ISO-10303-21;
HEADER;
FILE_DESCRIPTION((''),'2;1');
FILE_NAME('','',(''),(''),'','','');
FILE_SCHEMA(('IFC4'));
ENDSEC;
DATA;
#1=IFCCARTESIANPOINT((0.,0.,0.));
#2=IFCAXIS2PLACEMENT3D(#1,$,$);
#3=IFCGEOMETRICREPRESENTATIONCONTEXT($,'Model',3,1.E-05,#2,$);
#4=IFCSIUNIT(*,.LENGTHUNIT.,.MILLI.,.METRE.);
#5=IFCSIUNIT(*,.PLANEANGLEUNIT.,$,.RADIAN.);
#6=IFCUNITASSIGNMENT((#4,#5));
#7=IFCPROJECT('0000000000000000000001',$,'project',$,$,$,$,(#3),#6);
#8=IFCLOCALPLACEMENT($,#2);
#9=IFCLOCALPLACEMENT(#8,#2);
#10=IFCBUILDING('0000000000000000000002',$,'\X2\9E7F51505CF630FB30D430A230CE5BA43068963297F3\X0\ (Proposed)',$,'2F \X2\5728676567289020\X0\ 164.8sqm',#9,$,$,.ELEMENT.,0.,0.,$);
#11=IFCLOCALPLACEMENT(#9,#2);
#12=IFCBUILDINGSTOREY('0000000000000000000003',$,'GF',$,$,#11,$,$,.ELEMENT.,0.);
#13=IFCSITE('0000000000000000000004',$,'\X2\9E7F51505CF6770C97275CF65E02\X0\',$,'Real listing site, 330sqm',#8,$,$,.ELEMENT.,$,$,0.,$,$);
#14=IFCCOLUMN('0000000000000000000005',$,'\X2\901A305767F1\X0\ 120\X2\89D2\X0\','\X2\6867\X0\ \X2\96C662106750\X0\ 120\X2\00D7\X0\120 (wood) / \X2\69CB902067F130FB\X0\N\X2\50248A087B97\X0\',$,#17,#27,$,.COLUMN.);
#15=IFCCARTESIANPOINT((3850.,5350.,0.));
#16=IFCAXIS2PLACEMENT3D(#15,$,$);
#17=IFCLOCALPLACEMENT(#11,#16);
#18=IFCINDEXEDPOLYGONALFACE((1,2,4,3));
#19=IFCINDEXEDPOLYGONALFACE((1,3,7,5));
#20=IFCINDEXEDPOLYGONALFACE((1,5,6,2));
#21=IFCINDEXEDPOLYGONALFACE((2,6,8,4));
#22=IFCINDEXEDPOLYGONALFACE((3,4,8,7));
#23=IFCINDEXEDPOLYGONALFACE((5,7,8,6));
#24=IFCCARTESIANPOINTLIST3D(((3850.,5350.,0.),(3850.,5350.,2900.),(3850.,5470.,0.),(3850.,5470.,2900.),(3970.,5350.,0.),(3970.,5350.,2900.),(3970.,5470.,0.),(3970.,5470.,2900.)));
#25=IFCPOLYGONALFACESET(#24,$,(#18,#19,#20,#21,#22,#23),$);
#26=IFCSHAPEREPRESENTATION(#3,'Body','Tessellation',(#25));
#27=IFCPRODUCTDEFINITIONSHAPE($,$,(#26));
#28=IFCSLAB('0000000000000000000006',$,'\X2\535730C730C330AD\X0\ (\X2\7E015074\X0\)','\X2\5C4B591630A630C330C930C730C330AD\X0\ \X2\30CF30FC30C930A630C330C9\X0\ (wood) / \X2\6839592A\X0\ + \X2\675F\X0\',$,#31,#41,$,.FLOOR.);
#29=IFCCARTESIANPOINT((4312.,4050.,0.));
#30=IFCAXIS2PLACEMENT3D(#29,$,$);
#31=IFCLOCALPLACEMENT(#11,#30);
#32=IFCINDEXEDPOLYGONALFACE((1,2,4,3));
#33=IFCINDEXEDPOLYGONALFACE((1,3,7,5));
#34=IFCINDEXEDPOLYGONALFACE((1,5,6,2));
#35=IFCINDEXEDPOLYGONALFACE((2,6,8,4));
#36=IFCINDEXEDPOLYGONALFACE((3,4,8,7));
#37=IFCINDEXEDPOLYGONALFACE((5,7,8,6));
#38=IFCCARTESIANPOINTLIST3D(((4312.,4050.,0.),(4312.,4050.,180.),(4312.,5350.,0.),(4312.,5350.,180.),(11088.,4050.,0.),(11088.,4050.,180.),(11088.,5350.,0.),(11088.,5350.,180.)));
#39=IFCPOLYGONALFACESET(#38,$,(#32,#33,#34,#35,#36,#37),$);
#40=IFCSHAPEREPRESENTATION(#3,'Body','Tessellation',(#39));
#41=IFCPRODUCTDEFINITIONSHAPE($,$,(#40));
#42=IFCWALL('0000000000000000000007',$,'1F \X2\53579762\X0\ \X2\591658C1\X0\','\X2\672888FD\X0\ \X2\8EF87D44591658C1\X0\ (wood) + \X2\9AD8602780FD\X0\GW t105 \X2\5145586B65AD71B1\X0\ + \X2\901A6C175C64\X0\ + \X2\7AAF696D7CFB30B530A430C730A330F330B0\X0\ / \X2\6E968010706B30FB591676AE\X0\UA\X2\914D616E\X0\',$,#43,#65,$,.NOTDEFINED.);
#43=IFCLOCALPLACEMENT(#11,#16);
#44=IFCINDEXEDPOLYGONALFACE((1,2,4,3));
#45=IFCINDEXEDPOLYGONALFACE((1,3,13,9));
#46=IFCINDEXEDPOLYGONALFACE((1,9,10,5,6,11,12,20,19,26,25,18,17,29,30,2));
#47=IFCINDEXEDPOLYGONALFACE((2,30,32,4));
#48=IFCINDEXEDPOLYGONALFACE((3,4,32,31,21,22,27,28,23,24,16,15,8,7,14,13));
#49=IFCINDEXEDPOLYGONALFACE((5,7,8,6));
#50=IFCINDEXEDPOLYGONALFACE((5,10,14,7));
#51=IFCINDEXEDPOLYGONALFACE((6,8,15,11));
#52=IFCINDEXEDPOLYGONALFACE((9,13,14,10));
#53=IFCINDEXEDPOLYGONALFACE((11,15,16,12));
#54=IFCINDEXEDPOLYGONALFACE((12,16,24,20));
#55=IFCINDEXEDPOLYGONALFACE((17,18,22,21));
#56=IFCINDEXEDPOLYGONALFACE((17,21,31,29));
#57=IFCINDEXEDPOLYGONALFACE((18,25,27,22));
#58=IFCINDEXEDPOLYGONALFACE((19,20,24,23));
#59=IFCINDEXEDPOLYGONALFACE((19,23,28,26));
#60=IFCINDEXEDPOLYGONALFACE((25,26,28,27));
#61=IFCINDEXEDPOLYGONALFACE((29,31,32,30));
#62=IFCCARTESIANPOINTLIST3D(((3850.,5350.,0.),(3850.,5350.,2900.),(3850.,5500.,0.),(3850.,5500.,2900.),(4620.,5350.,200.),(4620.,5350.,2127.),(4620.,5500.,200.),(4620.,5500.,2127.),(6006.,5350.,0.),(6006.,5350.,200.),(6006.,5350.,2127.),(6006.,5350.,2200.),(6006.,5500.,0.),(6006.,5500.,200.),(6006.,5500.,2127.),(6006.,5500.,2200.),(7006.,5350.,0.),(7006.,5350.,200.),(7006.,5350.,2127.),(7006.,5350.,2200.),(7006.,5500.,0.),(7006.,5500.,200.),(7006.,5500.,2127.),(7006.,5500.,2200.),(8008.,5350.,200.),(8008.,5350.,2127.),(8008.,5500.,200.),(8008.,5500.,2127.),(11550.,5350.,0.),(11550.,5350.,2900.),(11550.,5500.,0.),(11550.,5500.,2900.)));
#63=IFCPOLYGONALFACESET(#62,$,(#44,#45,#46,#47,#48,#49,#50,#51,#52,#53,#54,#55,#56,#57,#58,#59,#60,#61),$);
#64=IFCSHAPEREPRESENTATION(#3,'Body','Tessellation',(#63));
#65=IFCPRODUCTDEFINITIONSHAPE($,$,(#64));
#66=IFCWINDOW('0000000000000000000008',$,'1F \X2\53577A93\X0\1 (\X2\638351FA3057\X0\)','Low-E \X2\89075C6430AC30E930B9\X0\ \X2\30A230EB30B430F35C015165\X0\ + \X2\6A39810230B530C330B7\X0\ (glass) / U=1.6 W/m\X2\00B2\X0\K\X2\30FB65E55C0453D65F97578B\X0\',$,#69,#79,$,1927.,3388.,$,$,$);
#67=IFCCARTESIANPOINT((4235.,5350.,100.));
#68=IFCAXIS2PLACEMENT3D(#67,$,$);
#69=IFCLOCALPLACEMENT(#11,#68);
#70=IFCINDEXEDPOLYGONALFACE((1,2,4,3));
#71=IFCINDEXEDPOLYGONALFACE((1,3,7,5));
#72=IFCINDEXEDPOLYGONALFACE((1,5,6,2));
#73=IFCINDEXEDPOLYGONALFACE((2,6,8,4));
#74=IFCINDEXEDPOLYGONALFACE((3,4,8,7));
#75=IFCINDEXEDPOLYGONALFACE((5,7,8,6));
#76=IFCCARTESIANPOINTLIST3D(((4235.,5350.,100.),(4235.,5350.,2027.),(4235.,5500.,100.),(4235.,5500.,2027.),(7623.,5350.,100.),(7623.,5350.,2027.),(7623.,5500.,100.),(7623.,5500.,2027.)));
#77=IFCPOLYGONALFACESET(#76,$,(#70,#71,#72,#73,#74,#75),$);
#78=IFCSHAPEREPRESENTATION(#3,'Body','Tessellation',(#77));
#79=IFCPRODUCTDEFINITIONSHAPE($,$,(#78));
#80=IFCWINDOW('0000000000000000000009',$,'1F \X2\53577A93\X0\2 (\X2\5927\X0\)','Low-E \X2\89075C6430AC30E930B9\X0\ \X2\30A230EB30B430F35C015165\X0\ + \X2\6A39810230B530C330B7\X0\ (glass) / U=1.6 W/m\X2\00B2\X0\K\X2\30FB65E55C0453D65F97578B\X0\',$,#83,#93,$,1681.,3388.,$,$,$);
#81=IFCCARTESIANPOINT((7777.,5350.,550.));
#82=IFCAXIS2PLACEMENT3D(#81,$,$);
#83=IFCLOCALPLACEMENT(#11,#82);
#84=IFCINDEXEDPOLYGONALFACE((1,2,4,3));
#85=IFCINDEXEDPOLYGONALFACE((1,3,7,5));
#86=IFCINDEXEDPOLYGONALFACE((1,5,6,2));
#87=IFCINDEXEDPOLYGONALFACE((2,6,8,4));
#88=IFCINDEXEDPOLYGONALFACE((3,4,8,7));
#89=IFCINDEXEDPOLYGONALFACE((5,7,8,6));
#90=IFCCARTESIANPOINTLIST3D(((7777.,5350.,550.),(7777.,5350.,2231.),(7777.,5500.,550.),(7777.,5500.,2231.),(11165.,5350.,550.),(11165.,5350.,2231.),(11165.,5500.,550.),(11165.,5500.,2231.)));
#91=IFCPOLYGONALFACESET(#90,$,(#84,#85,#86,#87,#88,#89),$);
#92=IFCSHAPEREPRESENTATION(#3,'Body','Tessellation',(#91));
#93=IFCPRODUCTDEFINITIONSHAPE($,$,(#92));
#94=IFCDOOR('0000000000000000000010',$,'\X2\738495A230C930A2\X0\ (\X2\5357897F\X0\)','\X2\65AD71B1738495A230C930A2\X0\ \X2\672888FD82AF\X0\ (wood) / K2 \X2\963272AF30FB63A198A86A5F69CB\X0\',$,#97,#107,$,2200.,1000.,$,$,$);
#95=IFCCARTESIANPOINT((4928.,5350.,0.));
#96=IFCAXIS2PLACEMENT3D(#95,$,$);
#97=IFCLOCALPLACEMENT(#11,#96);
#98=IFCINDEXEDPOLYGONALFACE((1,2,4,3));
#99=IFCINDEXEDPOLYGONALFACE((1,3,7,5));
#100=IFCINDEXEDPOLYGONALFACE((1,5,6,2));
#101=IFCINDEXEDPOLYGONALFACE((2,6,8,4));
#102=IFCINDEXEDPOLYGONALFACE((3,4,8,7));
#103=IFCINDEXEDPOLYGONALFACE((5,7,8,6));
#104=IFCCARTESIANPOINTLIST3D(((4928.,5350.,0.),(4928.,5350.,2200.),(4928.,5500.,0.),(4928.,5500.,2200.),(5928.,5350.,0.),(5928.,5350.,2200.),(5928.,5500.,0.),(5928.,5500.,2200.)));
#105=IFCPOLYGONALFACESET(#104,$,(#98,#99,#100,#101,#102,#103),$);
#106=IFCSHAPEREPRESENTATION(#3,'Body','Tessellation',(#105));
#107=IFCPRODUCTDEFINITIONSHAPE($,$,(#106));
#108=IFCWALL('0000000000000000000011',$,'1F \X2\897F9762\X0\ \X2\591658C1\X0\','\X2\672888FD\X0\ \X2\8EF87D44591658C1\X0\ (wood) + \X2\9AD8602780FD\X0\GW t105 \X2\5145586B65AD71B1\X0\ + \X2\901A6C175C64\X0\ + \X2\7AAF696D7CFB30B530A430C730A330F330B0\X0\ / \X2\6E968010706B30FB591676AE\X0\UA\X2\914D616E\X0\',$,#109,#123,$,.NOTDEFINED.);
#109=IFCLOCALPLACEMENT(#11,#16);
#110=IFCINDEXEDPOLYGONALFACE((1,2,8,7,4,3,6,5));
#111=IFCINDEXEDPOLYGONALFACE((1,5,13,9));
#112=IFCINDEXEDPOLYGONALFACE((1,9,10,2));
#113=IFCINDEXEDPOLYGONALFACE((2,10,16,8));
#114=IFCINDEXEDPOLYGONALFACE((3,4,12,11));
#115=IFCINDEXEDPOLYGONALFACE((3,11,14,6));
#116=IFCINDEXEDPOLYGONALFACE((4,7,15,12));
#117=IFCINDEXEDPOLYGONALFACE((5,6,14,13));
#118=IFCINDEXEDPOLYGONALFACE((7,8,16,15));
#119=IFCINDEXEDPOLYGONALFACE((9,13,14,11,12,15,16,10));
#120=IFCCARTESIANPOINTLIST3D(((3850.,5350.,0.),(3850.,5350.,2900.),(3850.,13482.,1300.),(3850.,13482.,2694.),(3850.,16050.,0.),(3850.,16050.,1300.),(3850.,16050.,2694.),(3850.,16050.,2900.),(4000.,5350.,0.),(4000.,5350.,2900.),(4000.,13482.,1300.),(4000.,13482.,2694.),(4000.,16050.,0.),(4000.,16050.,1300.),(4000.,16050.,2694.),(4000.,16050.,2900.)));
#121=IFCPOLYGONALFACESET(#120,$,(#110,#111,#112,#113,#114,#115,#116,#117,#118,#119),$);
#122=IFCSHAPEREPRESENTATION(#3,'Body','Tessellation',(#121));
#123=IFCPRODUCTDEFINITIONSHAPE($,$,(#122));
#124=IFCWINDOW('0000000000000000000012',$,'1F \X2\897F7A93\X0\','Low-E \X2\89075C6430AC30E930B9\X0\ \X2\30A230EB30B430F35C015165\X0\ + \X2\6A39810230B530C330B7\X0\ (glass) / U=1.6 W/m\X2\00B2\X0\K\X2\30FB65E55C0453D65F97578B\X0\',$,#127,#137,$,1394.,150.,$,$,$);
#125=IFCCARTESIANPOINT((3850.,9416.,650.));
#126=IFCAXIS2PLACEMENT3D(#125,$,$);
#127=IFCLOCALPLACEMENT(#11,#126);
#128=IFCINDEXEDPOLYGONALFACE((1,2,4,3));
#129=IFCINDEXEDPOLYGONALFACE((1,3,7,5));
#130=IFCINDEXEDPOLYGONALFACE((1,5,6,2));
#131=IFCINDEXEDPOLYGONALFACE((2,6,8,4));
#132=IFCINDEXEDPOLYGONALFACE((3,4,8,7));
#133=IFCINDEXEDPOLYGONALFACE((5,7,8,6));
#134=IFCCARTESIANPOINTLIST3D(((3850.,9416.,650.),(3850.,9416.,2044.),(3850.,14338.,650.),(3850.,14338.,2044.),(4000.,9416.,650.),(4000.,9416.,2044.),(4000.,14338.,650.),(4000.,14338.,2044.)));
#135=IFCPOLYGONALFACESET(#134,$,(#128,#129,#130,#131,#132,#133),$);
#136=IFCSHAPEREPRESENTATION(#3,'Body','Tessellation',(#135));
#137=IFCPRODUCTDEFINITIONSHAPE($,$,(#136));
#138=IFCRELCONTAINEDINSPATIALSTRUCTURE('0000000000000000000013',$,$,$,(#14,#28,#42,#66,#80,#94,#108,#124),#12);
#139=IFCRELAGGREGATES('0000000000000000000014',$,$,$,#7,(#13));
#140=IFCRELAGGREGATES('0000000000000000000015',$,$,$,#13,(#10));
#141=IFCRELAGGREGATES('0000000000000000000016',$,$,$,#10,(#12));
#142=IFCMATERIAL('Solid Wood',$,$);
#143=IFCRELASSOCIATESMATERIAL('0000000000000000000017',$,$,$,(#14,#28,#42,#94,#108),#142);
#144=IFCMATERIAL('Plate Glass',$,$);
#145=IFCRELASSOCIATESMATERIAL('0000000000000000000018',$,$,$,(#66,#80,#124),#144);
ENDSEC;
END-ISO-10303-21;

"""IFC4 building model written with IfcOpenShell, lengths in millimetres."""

from ifc_helpers import new_model, si_unit, frame, frame_2d, origin, place, context, project, spatial, rectangle, extrude, material, element, fill, save


model = new_model("IFC4")

# Units and contexts
model_context = context("Model", 3, precision=1e-05, world=origin())
ifc_project = project(units=[si_unit("LENGTHUNIT", "METRE", prefix="MILLI"), si_unit("PLANEANGLEUNIT", "RADIAN")], contexts=[model_context])

# Site, building, storey
site_placement = place(None, origin())
site = spatial("IfcSite", under=ifc_project, at=site_placement, Name="鹿児島県霧島市", ObjectType="Real listing site, 330sqm", CompositionType="ELEMENT", RefElevation=0.0)
building_placement = place(site_placement, origin())
building = spatial("IfcBuilding", under=site, at=building_placement, Name="鹿児島・ピアノ室と防音 (Proposed)", ObjectType="2F 在来木造 164.8sqm", CompositionType="ELEMENT", ElevationOfRefHeight=0.0, ElevationOfTerrain=0.0)
storey_placement = place(building_placement, origin())
storey = spatial("IfcBuildingStorey", under=building, at=storey_placement, Name="GF", CompositionType="ELEMENT", Elevation=0.0)

# Column
ifc_material_1 = material(Name="Solid Wood")
column_placement = place(storey_placement, frame((3850.0, 5350.0, 0.0)))
element("IfcColumn", 1, at=column_placement, inside=storey, material=ifc_material_1, Name="通し柱 120角", Description="桧 集成材 120×120 (wood) / 構造柱・N値計算", PredefinedType="COLUMN", context=model_context, shape_type="SweptSolid", body=[
    extrude(rectangle(XDim=120.0, YDim=120.0, at=frame_2d((60.0, 60.0))), frame((3850.0, 5350.0, 0.0)), (0.0, 0.0, 1.0), 2900.0),
])

# Slab
slab_1_placement = place(storey_placement, frame((4312.0, 4050.0, 0.0)))
element("IfcSlab", 2, at=slab_1_placement, inside=storey, material=ifc_material_1, Name="南デッキ (縁側)", Description="屋外ウッドデッキ ハードウッド (wood) / 根太 + 束", PredefinedType="FLOOR", context=model_context, shape_type="SweptSolid", body=[
    extrude(rectangle(XDim=6776.0, YDim=1300.0, at=frame_2d((3388.0, 650.0))), frame((4312.0, 4050.0, 0.0)), (0.0, 0.0, 1.0), 180.0),
])

# Wall, openings, windows, door
wall_1_placement = place(storey_placement, frame((3850.0, 5350.0, 0.0)))
wall_1 = element("IfcWall", 3, at=wall_1_placement, inside=storey, material=ifc_material_1, Name="1F 南面 外壁", Description="木製 軸組外壁 (wood) + 高性能GW t105 充填断熱 + 通気層 + 窯業系サイディング / 準耐火・外皮UA配慮", PredefinedType="NOTDEFINED", context=model_context, shape_type="SweptSolid", body=[
    extrude(rectangle(XDim=7700.0, YDim=150.0, at=frame_2d((3850.0, 75.0))), frame((3850.0, 5350.0, 0.0)), (0.0, 0.0, 1.0), 2900.0),
])
opening_1_placement = place(storey_placement, frame((4235.0, 5350.0, 100.0)))
opening_1 = element("IfcOpeningElement", 4, at=opening_1_placement, cuts=wall_1, PredefinedType="NOTDEFINED", context=model_context, shape_type="SweptSolid", body=[
    extrude(rectangle(XDim=3388.0, YDim=150.0, at=frame_2d((1694.0, 75.0))), frame((4235.0, 5350.0, 100.0)), (0.0, 0.0, 1.0), 1927.0),
])
opening_2_placement = place(storey_placement, frame((7777.0, 5350.0, 550.0)))
opening_2 = element("IfcOpeningElement", 5, at=opening_2_placement, cuts=wall_1, PredefinedType="NOTDEFINED", context=model_context, shape_type="SweptSolid", body=[
    extrude(rectangle(XDim=3388.0, YDim=150.0, at=frame_2d((1694.0, 75.0))), frame((7777.0, 5350.0, 550.0)), (0.0, 0.0, 1.0), 1681.0),
])
opening_3_placement = place(storey_placement, frame((4928.0, 5350.0, 0.0)))
opening_3 = element("IfcOpeningElement", 6, at=opening_3_placement, cuts=wall_1, PredefinedType="NOTDEFINED", context=model_context, shape_type="SweptSolid", body=[
    extrude(rectangle(XDim=1000.0, YDim=150.0, at=frame_2d((500.0, 75.0))), frame((4928.0, 5350.0, 0.0)), (0.0, 0.0, 1.0), 2200.0),
])
ifc_material_2 = material(Name="Plate Glass")
window_1_placement = place(storey_placement, frame((4235.0, 5350.0, 100.0)))
window_1 = element("IfcWindow", 7, at=window_1_placement, inside=storey, material=ifc_material_2, Name="1F 南窓1 (掃出し)", Description="Low-E 複層ガラス アルゴン封入 + 樹脂サッシ (glass) / U=1.6 W/m²K・日射取得型", OverallHeight=1927.0, OverallWidth=3388.0, context=model_context, shape_type="SweptSolid", body=[
    extrude(rectangle(XDim=3388.0, YDim=150.0, at=frame_2d((1694.0, 75.0))), frame((4235.0, 5350.0, 100.0)), (0.0, 0.0, 1.0), 1927.0),
])
fill(opening_1, window_1)
window_2_placement = place(storey_placement, frame((7777.0, 5350.0, 550.0)))
window_2 = element("IfcWindow", 8, at=window_2_placement, inside=storey, material=ifc_material_2, Name="1F 南窓2 (大)", Description="Low-E 複層ガラス アルゴン封入 + 樹脂サッシ (glass) / U=1.6 W/m²K・日射取得型", OverallHeight=1681.0, OverallWidth=3388.0, context=model_context, shape_type="SweptSolid", body=[
    extrude(rectangle(XDim=3388.0, YDim=150.0, at=frame_2d((1694.0, 75.0))), frame((7777.0, 5350.0, 550.0)), (0.0, 0.0, 1.0), 1681.0),
])
fill(opening_2, window_2)
door_placement = place(storey_placement, frame((4928.0, 5350.0, 0.0)))
door = element("IfcDoor", 9, at=door_placement, inside=storey, material=ifc_material_1, Name="玄関ドア (南西)", Description="断熱玄関ドア 木製芯 (wood) / K2 防犯・採風機構", OverallHeight=2200.0, OverallWidth=1000.0, context=model_context, shape_type="SweptSolid", body=[
    extrude(rectangle(XDim=1000.0, YDim=150.0, at=frame_2d((500.0, 75.0))), frame((4928.0, 5350.0, 0.0)), (0.0, 0.0, 1.0), 2200.0),
])
fill(opening_3, door)

# Wall, opening, window
wall_2_placement = place(storey_placement, frame((3850.0, 5350.0, 0.0)))
wall_2 = element("IfcWall", 10, at=wall_2_placement, inside=storey, material=ifc_material_1, Name="1F 西面 外壁", Description="木製 軸組外壁 (wood) + 高性能GW t105 充填断熱 + 通気層 + 窯業系サイディング / 準耐火・外皮UA配慮", PredefinedType="NOTDEFINED", context=model_context, shape_type="SweptSolid", body=[
    extrude(rectangle(XDim=150.0, YDim=10700.0, at=frame_2d((75.0, 5350.0))), frame((3850.0, 5350.0, 0.0)), (0.0, 0.0, 1.0), 2900.0),
])
opening_4_placement = place(storey_placement, frame((3850.0, 9416.0, 650.0)))
opening_4 = element("IfcOpeningElement", 11, at=opening_4_placement, cuts=wall_2, PredefinedType="NOTDEFINED", context=model_context, shape_type="SweptSolid", body=[
    extrude(rectangle(XDim=150.0, YDim=4922.0, at=frame_2d((75.0, 2461.0))), frame((3850.0, 9416.0, 650.0)), (0.0, 0.0, 1.0), 1394.0),
])
window_3_placement = place(storey_placement, frame((3850.0, 9416.0, 650.0)))
window_3 = element("IfcWindow", 12, at=window_3_placement, inside=storey, material=ifc_material_2, Name="1F 西窓", Description="Low-E 複層ガラス アルゴン封入 + 樹脂サッシ (glass) / U=1.6 W/m²K・日射取得型", OverallHeight=1394.0, OverallWidth=150.0, context=model_context, shape_type="SweptSolid", body=[
    extrude(rectangle(XDim=150.0, YDim=4922.0, at=frame_2d((75.0, 2461.0))), frame((3850.0, 9416.0, 650.0)), (0.0, 0.0, 1.0), 1394.0),
])
fill(opening_4, window_3)

save(model, "model.ifc")
